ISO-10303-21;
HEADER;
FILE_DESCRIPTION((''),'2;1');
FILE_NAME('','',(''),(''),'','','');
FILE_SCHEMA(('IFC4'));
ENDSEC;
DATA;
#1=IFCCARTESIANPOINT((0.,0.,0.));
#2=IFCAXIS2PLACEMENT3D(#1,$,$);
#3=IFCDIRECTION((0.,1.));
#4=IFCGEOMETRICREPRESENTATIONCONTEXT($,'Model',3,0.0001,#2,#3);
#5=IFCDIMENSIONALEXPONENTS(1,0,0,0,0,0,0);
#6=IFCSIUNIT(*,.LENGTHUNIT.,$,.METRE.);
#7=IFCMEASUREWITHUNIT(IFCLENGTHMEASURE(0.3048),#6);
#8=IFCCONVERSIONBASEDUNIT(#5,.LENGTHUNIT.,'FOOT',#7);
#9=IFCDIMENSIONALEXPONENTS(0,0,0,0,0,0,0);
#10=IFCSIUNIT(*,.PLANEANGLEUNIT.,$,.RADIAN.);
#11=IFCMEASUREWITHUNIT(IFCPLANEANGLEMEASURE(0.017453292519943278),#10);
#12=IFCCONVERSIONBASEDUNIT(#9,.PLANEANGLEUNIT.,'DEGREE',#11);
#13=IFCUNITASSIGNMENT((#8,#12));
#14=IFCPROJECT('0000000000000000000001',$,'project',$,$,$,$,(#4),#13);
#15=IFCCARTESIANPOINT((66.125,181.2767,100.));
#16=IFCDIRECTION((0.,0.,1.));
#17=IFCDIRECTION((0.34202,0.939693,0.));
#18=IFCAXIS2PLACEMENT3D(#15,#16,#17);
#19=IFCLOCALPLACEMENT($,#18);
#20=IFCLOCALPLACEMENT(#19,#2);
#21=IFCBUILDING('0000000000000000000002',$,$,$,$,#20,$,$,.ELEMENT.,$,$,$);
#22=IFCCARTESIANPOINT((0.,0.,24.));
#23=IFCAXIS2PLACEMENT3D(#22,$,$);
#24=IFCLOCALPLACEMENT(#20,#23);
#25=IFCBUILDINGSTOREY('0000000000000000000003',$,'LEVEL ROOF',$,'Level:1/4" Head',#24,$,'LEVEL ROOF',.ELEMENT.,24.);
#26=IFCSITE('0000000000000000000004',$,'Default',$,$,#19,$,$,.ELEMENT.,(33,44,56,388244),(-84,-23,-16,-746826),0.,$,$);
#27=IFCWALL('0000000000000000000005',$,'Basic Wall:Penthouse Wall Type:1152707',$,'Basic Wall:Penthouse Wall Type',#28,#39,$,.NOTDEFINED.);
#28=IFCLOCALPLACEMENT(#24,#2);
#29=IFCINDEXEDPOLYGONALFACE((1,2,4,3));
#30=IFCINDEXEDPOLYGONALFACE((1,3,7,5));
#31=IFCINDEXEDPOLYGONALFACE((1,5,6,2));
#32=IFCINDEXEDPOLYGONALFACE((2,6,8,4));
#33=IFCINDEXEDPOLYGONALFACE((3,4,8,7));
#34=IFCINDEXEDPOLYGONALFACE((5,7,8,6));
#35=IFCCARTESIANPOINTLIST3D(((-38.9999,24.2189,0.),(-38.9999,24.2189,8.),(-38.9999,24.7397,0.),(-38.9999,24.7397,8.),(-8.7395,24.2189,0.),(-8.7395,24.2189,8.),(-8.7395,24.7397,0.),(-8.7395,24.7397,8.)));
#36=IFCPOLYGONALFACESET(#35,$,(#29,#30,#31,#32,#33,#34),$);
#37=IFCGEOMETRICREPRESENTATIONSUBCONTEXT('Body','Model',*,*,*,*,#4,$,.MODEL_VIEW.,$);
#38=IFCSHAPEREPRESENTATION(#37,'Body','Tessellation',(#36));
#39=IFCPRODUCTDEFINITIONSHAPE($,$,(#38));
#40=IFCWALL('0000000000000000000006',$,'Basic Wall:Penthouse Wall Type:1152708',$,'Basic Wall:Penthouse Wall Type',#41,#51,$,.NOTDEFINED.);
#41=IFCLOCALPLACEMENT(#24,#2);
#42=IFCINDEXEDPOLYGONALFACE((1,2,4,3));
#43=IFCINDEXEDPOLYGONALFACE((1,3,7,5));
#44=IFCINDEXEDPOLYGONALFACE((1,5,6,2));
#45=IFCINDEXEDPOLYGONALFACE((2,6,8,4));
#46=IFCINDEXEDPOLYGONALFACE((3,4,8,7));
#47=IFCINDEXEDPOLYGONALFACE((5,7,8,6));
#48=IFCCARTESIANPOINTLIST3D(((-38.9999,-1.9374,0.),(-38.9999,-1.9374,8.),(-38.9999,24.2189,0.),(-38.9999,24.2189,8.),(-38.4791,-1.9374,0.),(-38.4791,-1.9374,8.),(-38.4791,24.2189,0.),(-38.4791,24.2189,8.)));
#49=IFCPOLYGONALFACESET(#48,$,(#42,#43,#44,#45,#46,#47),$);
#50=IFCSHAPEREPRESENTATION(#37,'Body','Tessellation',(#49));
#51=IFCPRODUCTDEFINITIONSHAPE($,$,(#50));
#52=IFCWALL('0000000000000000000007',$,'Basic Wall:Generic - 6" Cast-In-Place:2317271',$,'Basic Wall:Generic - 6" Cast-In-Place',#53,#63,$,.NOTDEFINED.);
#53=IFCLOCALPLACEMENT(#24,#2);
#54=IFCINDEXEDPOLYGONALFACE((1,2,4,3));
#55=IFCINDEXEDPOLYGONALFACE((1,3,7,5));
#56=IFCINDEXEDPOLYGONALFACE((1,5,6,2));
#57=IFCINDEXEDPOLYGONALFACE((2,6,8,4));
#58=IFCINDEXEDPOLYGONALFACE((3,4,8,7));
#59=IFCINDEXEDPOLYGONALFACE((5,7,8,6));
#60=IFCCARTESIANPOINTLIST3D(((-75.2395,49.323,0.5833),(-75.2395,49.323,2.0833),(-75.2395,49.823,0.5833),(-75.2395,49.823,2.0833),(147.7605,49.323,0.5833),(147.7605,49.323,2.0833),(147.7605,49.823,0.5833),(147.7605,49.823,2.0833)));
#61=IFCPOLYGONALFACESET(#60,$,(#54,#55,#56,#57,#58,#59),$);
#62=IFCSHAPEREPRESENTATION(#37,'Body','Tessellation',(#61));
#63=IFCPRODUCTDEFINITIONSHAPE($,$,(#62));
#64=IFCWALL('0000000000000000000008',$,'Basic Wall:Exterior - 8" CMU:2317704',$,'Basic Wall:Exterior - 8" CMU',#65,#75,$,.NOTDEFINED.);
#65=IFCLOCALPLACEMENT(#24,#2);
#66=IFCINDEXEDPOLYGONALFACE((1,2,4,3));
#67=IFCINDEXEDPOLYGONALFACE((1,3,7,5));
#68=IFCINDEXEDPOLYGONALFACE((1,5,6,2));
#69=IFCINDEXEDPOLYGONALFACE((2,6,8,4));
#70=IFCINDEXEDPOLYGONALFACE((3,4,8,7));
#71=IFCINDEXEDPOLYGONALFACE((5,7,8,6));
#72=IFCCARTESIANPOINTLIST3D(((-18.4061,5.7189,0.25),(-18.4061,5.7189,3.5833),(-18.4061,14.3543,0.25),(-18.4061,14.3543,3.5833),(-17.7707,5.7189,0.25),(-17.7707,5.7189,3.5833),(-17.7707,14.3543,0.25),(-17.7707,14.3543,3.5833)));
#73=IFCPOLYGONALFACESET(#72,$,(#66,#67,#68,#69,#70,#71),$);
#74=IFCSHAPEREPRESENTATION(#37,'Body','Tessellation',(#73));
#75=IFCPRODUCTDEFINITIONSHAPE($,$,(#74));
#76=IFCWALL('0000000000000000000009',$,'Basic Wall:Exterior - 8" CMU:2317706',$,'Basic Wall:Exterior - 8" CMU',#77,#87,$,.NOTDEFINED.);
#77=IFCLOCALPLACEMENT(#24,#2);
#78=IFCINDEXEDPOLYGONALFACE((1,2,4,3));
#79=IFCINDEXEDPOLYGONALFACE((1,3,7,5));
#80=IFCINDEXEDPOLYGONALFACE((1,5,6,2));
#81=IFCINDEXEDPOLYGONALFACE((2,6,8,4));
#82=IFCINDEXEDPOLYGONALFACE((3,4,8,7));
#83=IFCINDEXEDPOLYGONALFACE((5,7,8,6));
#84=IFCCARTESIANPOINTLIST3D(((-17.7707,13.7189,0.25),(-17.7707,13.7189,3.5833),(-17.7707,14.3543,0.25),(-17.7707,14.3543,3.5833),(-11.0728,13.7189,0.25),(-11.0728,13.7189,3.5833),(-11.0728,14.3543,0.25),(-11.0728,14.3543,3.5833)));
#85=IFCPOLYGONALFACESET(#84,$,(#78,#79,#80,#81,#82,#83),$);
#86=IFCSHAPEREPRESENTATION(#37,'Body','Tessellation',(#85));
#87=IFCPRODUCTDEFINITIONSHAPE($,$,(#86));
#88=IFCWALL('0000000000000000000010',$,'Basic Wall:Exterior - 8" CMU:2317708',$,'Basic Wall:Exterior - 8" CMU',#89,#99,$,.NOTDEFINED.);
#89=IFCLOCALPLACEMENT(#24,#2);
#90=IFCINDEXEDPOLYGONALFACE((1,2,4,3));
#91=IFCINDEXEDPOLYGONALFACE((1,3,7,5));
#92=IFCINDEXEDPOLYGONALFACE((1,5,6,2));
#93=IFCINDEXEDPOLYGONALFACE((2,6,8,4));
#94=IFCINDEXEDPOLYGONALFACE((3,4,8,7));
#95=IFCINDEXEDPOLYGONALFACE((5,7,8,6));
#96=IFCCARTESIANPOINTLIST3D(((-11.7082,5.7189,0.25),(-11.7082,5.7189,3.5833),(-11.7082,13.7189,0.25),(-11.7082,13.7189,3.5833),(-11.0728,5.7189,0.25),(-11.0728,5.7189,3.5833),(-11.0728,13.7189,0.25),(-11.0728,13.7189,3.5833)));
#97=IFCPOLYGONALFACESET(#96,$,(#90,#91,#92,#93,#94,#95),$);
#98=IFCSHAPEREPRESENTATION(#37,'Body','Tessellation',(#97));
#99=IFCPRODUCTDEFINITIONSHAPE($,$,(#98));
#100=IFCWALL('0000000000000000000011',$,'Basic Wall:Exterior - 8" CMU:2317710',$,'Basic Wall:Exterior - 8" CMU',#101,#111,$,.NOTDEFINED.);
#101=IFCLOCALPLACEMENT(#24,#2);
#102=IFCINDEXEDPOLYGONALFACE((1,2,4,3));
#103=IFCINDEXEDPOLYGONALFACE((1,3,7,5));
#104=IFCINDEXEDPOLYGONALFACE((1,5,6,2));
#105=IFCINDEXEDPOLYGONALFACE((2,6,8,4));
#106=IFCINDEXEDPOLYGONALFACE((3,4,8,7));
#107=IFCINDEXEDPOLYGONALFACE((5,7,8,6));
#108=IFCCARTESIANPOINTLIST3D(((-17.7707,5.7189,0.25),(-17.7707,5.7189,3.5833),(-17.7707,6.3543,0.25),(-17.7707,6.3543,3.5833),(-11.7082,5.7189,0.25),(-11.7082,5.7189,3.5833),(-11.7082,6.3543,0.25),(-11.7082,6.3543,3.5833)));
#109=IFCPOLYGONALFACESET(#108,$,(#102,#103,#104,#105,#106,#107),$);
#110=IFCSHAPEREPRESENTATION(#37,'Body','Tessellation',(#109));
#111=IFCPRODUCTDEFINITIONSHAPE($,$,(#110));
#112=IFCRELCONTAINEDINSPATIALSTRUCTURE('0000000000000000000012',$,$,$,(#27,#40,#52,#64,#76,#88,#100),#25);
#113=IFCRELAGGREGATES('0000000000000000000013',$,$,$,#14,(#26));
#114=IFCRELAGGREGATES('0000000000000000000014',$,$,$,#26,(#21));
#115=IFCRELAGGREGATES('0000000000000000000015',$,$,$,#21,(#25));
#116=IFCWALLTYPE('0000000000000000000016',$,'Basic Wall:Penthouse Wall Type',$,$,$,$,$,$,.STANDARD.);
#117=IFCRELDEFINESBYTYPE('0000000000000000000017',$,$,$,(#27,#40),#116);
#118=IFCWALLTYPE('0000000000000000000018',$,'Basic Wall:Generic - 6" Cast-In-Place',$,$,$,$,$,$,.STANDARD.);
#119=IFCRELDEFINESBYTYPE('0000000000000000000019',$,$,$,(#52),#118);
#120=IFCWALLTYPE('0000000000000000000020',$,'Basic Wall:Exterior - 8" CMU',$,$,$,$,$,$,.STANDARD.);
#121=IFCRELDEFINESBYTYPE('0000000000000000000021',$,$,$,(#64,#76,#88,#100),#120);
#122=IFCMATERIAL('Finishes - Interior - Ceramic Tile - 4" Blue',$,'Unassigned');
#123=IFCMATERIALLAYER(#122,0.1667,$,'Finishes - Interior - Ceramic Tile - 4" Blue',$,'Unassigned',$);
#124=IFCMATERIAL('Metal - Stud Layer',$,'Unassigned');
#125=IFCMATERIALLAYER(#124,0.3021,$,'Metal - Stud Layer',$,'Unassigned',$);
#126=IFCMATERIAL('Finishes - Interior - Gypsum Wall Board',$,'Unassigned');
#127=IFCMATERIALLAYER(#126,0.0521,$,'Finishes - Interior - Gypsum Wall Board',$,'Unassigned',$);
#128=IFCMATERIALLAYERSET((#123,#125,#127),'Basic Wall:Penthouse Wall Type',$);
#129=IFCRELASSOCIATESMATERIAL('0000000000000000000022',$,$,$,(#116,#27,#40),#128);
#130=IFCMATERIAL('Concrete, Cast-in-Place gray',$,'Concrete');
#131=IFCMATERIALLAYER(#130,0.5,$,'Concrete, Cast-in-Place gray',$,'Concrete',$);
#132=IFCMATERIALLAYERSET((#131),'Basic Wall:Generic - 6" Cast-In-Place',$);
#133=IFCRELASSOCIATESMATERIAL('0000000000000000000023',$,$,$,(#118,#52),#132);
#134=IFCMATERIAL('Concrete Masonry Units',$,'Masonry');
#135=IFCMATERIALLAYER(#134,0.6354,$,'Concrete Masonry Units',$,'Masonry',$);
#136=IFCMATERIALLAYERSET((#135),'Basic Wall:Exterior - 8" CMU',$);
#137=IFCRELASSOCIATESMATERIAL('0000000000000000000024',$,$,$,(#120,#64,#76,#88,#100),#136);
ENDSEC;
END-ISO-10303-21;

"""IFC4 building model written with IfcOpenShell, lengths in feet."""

from ifc_helpers import new_model, entity, si_unit, converted_unit, direction, frame, frame_2d, origin, place, context, subcontext, project, spatial, rectangle, extrude, material, layer, layer_set, layer_usage, type_object, element, save


model = new_model("IFC4")

# Units and contexts
model_context = context("Model", 3, precision=0.0001, world=origin(), true_north=direction((0.0, 1.0)))
body_context = subcontext(model_context, "Body", "Model", "MODEL_VIEW")
ifc_project = project(units=[converted_unit("LENGTHUNIT", "FOOT", entity("IfcLengthMeasure", 0.3048), si_unit("LENGTHUNIT", "METRE"), dimensions=[1, 0, 0, 0, 0, 0, 0]), converted_unit("PLANEANGLEUNIT", "DEGREE", entity("IfcPlaneAngleMeasure", 0.017453292519943278), si_unit("PLANEANGLEUNIT", "RADIAN"), dimensions=[0, 0, 0, 0, 0, 0, 0])], contexts=[model_context])

# Site, building, storey
site_placement = place(None, frame((66.125, 181.2767, 100.0), z_axis=(0.0, 0.0, 1.0), x_axis=(0.34202, 0.939693, 0.0)))
site = spatial("IfcSite", under=ifc_project, at=site_placement, Name="Default", CompositionType="ELEMENT", RefLatitude=(33, 44, 56, 388244), RefLongitude=(-84, -23, -16, -746826), RefElevation=0.0)
building_placement = place(site_placement, origin())
building = spatial("IfcBuilding", under=site, at=building_placement, CompositionType="ELEMENT")
storey_placement = place(building_placement, frame((0.0, 0.0, 24.0)))
storey = spatial("IfcBuildingStorey", under=building, at=storey_placement, Name="LEVEL ROOF", ObjectType="Level:1/4\" Head", LongName="LEVEL ROOF", CompositionType="ELEMENT", Elevation=24.0)

# Walls
ifc_material_1 = material(Name="Finishes - Interior - Ceramic Tile - 4\" Blue", Category="Unassigned")
ifc_layer_1 = layer(ifc_material_1, 0.1667, Name="Finishes - Interior - Ceramic Tile - 4\" Blue", Category="Unassigned")
ifc_material_2 = material(Name="Metal - Stud Layer", Category="Unassigned")
ifc_layer_2 = layer(ifc_material_2, 0.3021, Name="Metal - Stud Layer", Category="Unassigned")
ifc_material_3 = material(Name="Finishes - Interior - Gypsum Wall Board", Category="Unassigned")
ifc_layer_3 = layer(ifc_material_3, 0.0521, Name="Finishes - Interior - Gypsum Wall Board", Category="Unassigned")
ifc_layer_set_1 = layer_set([ifc_layer_1, ifc_layer_2, ifc_layer_3], Name="Basic Wall:Penthouse Wall Type")
ifc_layer_usage_1 = layer_usage(ifc_layer_set_1, "AXIS2", "NEGATIVE", 0.2604)
wall_type_1 = type_object("IfcWallType", Name="Basic Wall:Penthouse Wall Type", PredefinedType="STANDARD", material=ifc_layer_set_1)
wall_1_placement = place(storey_placement, frame((-38.9999, 24.4793, 0.0)))
element("IfcWall", 1, at=wall_1_placement, inside=storey, type_object=wall_type_1, material=ifc_layer_usage_1, Name="Basic Wall:Penthouse Wall Type:1152707", ObjectType="Basic Wall:Penthouse Wall Type", PredefinedType="NOTDEFINED", context=body_context, shape_type="SweptSolid", body=[
    extrude(rectangle(XDim=30.2604, YDim=0.5208, at=frame_2d((15.1302, 0.0), x_axis=(-1.0, 0.0))), origin(), (0.0, 0.0, 1.0), 8.0),
])
wall_2_placement = place(storey_placement, frame((-38.7395, -1.9374, 0.0), z_axis=(0.0, 0.0, 1.0), x_axis=(0.0, 1.0, 0.0)))
element("IfcWall", 2, at=wall_2_placement, inside=storey, type_object=wall_type_1, material=ifc_layer_usage_1, Name="Basic Wall:Penthouse Wall Type:1152708", ObjectType="Basic Wall:Penthouse Wall Type", PredefinedType="NOTDEFINED", context=body_context, shape_type="SweptSolid", body=[
    extrude(rectangle(XDim=26.1563, YDim=0.5208, at=frame_2d((13.0781, 0.0), x_axis=(-1.0, 0.0))), origin(), (0.0, 0.0, 1.0), 8.0),
])
ifc_material_4 = material(Name="Concrete, Cast-in-Place gray", Category="Concrete")
ifc_layer_4 = layer(ifc_material_4, 0.5, Name="Concrete, Cast-in-Place gray", Category="Concrete")
ifc_layer_set_2 = layer_set([ifc_layer_4], Name="Basic Wall:Generic - 6\" Cast-In-Place")
ifc_layer_usage_2 = layer_usage(ifc_layer_set_2, "AXIS2", "NEGATIVE", 0.25)
wall_type_2 = type_object("IfcWallType", Name="Basic Wall:Generic - 6\" Cast-In-Place", PredefinedType="STANDARD", material=ifc_layer_set_2)
wall_3_placement = place(storey_placement, frame((-75.2395, 49.573, 0.5833)))
element("IfcWall", 3, at=wall_3_placement, inside=storey, type_object=wall_type_2, material=ifc_layer_usage_2, Name="Basic Wall:Generic - 6\" Cast-In-Place:2317271", ObjectType="Basic Wall:Generic - 6\" Cast-In-Place", PredefinedType="NOTDEFINED", context=body_context, shape_type="SweptSolid", body=[
    extrude(rectangle(XDim=223.0, YDim=0.5, at=frame_2d((111.5, 0.0), x_axis=(-1.0, 0.0))), origin(), (0.0, 0.0, 1.0), 1.5),
])
ifc_material_5 = material(Name="Concrete Masonry Units", Category="Masonry")
ifc_layer_5 = layer(ifc_material_5, 0.6354, Name="Concrete Masonry Units", Category="Masonry")
ifc_layer_set_3 = layer_set([ifc_layer_5], Name="Basic Wall:Exterior - 8\" CMU")
ifc_layer_usage_3 = layer_usage(ifc_layer_set_3, "AXIS2", "NEGATIVE", 0.3177)
wall_type_3 = type_object("IfcWallType", Name="Basic Wall:Exterior - 8\" CMU", PredefinedType="STANDARD", material=ifc_layer_set_3)
wall_4_placement = place(storey_placement, frame((-18.0884, 5.7189, 0.25), z_axis=(0.0, 0.0, 1.0), x_axis=(0.0, 1.0, 0.0)))
element("IfcWall", 4, at=wall_4_placement, inside=storey, type_object=wall_type_3, material=ifc_layer_usage_3, Name="Basic Wall:Exterior - 8\" CMU:2317704", ObjectType="Basic Wall:Exterior - 8\" CMU", PredefinedType="NOTDEFINED", context=body_context, shape_type="SweptSolid", body=[
    extrude(rectangle(XDim=8.6354, YDim=0.6354, at=frame_2d((4.3177, 0.0), x_axis=(-1.0, 0.0))), origin(), (0.0, 0.0, 1.0), 3.3333),
])
wall_5_placement = place(storey_placement, frame((-17.7707, 14.0366, 0.25)))
element("IfcWall", 5, at=wall_5_placement, inside=storey, type_object=wall_type_3, material=ifc_layer_usage_3, Name="Basic Wall:Exterior - 8\" CMU:2317706", ObjectType="Basic Wall:Exterior - 8\" CMU", PredefinedType="NOTDEFINED", context=body_context, shape_type="SweptSolid", body=[
    extrude(rectangle(XDim=6.6979, YDim=0.6354, at=frame_2d((3.349, 0.0), x_axis=(-1.0, 0.0))), origin(), (0.0, 0.0, 1.0), 3.3333),
])
wall_6_placement = place(storey_placement, frame((-11.3905, 13.7189, 0.25), z_axis=(0.0, 0.0, 1.0), x_axis=(0.0, -1.0, 0.0)))
element("IfcWall", 6, at=wall_6_placement, inside=storey, type_object=wall_type_3, material=ifc_layer_usage_3, Name="Basic Wall:Exterior - 8\" CMU:2317708", ObjectType="Basic Wall:Exterior - 8\" CMU", PredefinedType="NOTDEFINED", context=body_context, shape_type="SweptSolid", body=[
    extrude(rectangle(XDim=8.0, YDim=0.6354, at=frame_2d((4.0, 0.0), x_axis=(-1.0, 0.0))), origin(), (0.0, 0.0, 1.0), 3.3333),
])
wall_7_placement = place(storey_placement, frame((-11.7082, 6.0366, 0.25), z_axis=(0.0, 0.0, 1.0), x_axis=(-1.0, 0.0, 0.0)))
element("IfcWall", 7, at=wall_7_placement, inside=storey, type_object=wall_type_3, material=ifc_layer_usage_3, Name="Basic Wall:Exterior - 8\" CMU:2317710", ObjectType="Basic Wall:Exterior - 8\" CMU", PredefinedType="NOTDEFINED", context=body_context, shape_type="SweptSolid", body=[
    extrude(rectangle(XDim=6.0625, YDim=0.6354, at=frame_2d((3.0312, 0.0), x_axis=(-1.0, 0.0))), origin(), (0.0, 0.0, 1.0), 3.3333),
])

save(model, "model.ifc")
